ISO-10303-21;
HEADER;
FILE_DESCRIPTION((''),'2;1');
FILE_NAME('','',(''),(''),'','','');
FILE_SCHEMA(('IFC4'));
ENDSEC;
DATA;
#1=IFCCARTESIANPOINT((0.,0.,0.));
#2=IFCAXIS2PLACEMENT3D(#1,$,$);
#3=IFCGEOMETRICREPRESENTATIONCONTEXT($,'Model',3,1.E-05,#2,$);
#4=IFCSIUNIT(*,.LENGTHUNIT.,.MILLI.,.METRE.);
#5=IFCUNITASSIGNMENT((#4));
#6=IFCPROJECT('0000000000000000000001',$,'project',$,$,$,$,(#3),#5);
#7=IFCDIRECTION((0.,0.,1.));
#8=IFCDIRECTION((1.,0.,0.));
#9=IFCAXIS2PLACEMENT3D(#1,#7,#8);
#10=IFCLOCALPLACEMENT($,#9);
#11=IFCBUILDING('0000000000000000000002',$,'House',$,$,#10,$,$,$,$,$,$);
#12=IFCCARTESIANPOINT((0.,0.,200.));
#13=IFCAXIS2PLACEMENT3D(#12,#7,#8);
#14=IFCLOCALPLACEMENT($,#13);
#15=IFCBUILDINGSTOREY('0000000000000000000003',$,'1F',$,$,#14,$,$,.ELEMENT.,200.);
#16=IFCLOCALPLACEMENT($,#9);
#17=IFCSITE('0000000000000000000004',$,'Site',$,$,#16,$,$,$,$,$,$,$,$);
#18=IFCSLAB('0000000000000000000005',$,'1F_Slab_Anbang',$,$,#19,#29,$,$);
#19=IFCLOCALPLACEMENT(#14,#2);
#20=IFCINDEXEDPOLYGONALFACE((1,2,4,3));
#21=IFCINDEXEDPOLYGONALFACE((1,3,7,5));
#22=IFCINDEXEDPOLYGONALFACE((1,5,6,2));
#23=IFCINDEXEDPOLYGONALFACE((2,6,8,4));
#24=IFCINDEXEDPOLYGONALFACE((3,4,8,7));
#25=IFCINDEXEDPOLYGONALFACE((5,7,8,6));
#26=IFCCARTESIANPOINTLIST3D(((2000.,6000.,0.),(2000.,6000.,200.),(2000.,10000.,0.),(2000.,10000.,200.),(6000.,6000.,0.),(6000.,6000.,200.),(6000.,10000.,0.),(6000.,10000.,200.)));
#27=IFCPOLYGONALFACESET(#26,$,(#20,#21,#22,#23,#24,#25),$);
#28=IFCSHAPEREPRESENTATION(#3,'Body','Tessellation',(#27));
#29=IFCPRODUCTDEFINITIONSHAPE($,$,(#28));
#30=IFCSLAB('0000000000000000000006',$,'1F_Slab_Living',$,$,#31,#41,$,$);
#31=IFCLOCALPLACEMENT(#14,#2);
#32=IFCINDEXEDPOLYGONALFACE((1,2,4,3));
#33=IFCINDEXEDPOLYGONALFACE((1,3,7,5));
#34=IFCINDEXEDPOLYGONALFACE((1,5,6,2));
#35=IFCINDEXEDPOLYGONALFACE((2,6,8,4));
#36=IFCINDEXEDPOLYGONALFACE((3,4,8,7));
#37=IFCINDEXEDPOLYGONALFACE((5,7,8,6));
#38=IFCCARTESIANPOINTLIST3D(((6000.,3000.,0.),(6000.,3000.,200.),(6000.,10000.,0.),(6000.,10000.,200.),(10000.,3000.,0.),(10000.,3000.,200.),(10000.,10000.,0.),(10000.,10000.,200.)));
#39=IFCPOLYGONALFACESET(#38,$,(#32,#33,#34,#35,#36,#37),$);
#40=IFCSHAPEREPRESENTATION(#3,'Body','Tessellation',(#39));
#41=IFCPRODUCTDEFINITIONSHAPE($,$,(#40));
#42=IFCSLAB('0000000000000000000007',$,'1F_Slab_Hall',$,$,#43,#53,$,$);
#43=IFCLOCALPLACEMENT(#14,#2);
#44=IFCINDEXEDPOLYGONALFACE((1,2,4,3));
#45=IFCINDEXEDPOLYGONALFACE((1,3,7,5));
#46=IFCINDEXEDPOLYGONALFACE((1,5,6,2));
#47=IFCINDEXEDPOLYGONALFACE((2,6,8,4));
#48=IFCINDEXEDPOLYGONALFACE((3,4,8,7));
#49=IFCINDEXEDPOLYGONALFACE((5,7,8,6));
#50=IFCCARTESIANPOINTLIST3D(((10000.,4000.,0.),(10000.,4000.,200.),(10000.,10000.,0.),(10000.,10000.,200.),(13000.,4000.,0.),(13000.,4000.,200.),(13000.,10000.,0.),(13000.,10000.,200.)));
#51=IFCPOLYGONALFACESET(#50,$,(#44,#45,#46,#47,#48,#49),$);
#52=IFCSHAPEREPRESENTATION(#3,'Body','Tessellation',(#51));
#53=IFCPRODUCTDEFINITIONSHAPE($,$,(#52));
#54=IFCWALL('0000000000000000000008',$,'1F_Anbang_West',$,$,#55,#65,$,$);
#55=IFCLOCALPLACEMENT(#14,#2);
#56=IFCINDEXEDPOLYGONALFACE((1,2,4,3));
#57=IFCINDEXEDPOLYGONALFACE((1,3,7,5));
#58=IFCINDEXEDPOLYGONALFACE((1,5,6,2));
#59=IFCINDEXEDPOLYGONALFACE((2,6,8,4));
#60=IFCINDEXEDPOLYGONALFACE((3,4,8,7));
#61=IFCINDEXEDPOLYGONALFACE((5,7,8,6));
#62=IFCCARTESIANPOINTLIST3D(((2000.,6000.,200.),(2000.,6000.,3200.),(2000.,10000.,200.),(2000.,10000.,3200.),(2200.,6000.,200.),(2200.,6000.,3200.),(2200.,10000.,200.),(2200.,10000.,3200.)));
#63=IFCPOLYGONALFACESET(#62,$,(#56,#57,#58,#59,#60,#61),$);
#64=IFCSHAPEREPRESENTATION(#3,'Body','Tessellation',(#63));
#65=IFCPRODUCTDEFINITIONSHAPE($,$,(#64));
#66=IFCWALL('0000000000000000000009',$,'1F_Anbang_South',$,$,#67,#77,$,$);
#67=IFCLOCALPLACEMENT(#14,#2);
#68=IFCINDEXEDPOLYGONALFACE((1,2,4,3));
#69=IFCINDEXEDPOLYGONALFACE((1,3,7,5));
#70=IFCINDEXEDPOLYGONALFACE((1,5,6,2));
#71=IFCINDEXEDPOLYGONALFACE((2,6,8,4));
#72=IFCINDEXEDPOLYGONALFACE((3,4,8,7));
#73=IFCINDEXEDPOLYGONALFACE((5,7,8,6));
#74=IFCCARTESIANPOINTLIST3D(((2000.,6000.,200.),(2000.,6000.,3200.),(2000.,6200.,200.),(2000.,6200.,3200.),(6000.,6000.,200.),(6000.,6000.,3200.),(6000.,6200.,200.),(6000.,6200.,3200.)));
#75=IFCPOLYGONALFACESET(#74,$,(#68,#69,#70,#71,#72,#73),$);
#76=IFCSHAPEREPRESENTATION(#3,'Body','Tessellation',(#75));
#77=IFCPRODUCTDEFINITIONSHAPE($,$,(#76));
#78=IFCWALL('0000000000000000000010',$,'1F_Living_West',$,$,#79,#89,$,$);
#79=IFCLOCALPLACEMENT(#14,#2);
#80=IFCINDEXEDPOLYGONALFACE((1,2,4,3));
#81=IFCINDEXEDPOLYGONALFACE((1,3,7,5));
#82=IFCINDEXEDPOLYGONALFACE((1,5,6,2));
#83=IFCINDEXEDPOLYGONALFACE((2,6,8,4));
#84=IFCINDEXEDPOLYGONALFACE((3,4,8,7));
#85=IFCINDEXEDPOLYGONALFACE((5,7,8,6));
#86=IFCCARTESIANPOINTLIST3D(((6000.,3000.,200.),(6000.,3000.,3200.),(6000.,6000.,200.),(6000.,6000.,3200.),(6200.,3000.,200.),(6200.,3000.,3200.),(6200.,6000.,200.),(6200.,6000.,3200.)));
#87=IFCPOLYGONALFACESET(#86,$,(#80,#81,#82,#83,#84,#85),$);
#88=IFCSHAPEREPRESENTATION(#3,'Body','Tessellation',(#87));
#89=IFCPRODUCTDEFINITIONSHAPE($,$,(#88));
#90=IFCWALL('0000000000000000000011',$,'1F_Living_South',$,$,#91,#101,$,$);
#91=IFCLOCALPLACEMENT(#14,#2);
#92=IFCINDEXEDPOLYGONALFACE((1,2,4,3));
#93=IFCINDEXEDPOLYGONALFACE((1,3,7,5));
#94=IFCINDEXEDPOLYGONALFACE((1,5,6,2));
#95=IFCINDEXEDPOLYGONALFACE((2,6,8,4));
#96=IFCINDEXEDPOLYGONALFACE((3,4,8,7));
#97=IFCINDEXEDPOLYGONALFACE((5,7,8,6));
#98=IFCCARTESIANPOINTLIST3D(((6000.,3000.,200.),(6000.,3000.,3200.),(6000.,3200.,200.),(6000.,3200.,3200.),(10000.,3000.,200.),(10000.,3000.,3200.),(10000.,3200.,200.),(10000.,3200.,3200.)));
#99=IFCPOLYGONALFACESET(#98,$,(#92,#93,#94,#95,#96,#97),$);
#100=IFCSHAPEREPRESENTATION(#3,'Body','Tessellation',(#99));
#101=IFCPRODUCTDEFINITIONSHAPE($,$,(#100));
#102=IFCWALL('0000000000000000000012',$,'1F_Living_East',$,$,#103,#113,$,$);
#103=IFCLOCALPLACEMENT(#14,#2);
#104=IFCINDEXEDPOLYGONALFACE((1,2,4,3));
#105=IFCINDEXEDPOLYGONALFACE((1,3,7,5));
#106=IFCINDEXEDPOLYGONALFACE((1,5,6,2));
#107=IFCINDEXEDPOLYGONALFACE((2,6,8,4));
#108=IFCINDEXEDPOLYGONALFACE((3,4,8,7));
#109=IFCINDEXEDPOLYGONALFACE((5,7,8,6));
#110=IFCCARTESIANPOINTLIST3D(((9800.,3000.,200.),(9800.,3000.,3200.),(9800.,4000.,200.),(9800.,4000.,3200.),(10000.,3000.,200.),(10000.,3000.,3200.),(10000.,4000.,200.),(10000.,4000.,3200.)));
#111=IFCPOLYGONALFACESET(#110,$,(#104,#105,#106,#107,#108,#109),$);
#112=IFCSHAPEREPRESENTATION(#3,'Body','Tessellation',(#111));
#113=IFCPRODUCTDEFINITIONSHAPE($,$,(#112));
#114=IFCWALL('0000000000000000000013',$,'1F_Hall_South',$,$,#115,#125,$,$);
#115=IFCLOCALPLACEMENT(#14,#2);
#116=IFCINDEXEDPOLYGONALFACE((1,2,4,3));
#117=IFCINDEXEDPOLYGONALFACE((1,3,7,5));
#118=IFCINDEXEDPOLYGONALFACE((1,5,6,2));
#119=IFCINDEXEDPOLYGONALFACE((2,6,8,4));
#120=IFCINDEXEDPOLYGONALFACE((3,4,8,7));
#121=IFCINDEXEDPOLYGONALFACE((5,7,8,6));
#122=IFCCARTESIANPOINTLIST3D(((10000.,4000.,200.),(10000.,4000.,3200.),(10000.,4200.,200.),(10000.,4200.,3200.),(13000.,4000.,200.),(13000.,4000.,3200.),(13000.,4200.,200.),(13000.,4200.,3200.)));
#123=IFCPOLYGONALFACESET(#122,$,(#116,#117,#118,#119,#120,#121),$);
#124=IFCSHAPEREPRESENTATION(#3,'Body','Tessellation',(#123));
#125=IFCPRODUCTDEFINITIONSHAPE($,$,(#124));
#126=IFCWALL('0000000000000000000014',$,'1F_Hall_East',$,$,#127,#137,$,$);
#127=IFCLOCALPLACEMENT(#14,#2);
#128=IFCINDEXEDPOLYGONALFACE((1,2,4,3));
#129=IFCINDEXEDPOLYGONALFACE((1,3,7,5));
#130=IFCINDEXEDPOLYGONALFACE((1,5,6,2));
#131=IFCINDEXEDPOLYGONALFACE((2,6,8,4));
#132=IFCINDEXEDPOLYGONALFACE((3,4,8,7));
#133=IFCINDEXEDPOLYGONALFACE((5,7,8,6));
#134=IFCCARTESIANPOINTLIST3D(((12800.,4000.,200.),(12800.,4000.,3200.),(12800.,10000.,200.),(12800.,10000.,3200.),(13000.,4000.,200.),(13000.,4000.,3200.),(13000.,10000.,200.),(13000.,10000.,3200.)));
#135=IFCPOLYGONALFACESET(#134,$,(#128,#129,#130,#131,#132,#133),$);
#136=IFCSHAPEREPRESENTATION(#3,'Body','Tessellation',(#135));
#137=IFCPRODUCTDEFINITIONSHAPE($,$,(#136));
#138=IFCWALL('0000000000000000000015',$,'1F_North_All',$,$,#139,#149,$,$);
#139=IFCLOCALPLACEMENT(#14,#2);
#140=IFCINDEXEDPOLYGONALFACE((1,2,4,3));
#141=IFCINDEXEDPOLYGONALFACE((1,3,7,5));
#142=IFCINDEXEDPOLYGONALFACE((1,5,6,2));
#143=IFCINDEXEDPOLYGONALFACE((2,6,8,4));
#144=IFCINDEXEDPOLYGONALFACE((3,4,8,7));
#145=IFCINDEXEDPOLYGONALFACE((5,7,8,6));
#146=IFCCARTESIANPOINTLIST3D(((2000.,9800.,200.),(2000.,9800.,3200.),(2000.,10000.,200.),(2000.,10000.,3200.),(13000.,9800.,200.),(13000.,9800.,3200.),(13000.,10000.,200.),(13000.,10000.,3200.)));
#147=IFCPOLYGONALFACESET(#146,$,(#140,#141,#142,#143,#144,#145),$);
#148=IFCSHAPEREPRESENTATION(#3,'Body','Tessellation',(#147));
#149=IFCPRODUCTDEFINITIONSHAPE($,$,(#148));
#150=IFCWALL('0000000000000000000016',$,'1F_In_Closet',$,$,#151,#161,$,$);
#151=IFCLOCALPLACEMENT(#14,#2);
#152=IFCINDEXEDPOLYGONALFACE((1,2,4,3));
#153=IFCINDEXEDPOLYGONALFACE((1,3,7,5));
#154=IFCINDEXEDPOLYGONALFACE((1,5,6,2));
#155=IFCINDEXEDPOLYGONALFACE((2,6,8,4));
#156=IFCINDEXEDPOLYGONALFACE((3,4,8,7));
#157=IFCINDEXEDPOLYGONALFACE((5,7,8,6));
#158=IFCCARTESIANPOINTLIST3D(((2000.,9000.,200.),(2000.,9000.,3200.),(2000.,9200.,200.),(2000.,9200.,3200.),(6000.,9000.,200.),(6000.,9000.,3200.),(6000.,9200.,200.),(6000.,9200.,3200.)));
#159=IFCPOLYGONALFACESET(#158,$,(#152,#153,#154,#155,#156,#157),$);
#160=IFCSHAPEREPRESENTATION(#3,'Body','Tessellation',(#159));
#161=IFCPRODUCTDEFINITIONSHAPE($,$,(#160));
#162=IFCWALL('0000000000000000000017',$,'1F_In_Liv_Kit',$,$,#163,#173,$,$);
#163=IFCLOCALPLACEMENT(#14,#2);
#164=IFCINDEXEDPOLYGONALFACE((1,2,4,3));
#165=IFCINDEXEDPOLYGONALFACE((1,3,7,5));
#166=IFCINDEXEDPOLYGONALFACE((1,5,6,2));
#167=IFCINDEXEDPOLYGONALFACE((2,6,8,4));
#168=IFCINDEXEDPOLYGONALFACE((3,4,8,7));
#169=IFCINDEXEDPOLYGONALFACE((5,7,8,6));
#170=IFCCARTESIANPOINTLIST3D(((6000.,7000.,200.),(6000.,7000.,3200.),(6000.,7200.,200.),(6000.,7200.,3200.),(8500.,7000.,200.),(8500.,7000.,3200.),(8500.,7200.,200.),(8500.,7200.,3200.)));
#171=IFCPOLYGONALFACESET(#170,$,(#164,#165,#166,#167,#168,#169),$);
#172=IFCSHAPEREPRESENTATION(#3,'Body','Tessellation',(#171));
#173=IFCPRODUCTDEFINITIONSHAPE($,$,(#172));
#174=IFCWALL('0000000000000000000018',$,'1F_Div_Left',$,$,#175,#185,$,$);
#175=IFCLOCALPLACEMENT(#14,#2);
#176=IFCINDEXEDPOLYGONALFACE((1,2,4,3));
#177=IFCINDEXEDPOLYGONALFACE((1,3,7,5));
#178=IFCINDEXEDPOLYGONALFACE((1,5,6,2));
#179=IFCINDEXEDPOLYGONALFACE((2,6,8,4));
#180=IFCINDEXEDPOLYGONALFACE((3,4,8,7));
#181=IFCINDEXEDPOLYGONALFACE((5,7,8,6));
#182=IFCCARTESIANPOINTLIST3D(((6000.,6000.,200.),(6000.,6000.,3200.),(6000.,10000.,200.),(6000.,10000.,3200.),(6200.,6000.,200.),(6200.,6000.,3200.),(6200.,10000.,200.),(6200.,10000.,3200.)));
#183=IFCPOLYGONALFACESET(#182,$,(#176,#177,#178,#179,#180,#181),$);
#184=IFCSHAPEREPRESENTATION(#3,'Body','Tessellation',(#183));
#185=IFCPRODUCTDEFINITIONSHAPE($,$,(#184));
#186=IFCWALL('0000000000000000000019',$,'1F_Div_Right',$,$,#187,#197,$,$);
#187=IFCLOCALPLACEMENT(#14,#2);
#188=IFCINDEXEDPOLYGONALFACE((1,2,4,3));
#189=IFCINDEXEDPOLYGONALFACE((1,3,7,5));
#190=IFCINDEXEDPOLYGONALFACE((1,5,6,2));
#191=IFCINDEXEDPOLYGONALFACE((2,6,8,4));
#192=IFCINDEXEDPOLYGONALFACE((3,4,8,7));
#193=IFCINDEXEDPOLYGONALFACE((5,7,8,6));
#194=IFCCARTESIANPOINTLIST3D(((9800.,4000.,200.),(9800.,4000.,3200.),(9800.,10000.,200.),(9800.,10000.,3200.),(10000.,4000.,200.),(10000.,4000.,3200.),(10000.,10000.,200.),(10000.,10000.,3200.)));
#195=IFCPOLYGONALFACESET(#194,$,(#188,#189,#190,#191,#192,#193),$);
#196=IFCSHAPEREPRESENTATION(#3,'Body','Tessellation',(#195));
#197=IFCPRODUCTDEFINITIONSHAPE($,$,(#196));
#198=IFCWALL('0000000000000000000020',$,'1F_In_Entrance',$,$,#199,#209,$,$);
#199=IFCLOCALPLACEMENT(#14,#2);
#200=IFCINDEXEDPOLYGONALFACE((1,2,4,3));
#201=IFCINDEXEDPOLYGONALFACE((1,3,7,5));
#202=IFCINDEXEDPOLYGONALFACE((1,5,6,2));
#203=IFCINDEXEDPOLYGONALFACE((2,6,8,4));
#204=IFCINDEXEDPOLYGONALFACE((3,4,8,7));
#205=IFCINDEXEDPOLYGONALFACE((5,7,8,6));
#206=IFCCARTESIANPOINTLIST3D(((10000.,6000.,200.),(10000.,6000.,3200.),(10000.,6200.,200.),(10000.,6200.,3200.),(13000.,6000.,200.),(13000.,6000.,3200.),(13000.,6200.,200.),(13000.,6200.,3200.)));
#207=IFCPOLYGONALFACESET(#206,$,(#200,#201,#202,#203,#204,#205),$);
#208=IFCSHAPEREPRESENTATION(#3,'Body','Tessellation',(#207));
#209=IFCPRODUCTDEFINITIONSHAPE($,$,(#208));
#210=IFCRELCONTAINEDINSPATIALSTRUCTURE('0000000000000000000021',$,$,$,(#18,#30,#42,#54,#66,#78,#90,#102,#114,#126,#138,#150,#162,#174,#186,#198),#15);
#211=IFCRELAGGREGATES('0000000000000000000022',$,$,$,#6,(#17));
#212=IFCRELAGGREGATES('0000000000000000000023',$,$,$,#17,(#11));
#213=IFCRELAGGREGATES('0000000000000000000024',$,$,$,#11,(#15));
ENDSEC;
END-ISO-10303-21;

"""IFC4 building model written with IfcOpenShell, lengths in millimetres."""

from ifc_helpers import new_model, si_unit, frame, origin, origin_with_axes, place, context, project, spatial, rectangle, extrude, element, save


model = new_model("IFC4")

# Units and contexts
model_context = context("Model", 3, precision=1e-05, world=origin())
ifc_project = project(units=[si_unit("LENGTHUNIT", "METRE", prefix="MILLI")], contexts=[model_context])

# Site, building, storey
site_placement = place(None, origin_with_axes())
site = spatial("IfcSite", under=ifc_project, at=site_placement, Name="Site")
building_placement = place(None, origin_with_axes())
building = spatial("IfcBuilding", under=site, at=building_placement, Name="House")
storey_placement = place(None, frame((0.0, 0.0, 200.0), z_axis=(0.0, 0.0, 1.0), x_axis=(1.0, 0.0, 0.0)))
storey = spatial("IfcBuildingStorey", under=building, at=storey_placement, Name="1F", CompositionType="ELEMENT", Elevation=200.0)

# Slabs
slab_1_placement = place(None, frame((2000.0, 6000.0, 200.0), z_axis=(0.0, 0.0, 1.0), x_axis=(1.0, 0.0, 0.0)))
element("IfcSlab", 1, at=slab_1_placement, inside=storey, Name="1F_Slab_Anbang", context=model_context, shape_type="SweptSolid", body=[
    extrude(rectangle(XDim=4000.0, YDim=4000.0), frame((2000.0, 2000.0, 0.0)), (0.0, 0.0, 1.0), 200.0),
])
slab_2_placement = place(None, frame((6000.0, 3000.0, 200.0), z_axis=(0.0, 0.0, 1.0), x_axis=(1.0, 0.0, 0.0)))
element("IfcSlab", 2, at=slab_2_placement, inside=storey, Name="1F_Slab_Living", context=model_context, shape_type="SweptSolid", body=[
    extrude(rectangle(XDim=4000.0, YDim=7000.0), frame((2000.0, 3500.0, 0.0)), (0.0, 0.0, 1.0), 200.0),
])
slab_3_placement = place(None, frame((10000.0, 4000.0, 200.0), z_axis=(0.0, 0.0, 1.0), x_axis=(1.0, 0.0, 0.0)))
element("IfcSlab", 3, at=slab_3_placement, inside=storey, Name="1F_Slab_Hall", context=model_context, shape_type="SweptSolid", body=[
    extrude(rectangle(XDim=3000.0, YDim=6000.0), frame((1500.0, 3000.0, 0.0)), (0.0, 0.0, 1.0), 200.0),
])

# Walls
wall_1_placement = place(None, frame((2000.0, 6000.0, 400.0), z_axis=(0.0, 0.0, 1.0), x_axis=(1.0, 0.0, 0.0)))
element("IfcWall", 4, at=wall_1_placement, inside=storey, Name="1F_Anbang_West", context=model_context, shape_type="SweptSolid", body=[
    extrude(rectangle(XDim=200.0, YDim=4000.0), frame((100.0, 2000.0, 0.0)), (0.0, 0.0, 1.0), 3000.0),
])
wall_2_placement = place(None, frame((2000.0, 6000.0, 400.0), z_axis=(0.0, 0.0, 1.0), x_axis=(1.0, 0.0, 0.0)))
element("IfcWall", 5, at=wall_2_placement, inside=storey, Name="1F_Anbang_South", context=model_context, shape_type="SweptSolid", body=[
    extrude(rectangle(XDim=4000.0, YDim=200.0), frame((2000.0, 100.0, 0.0)), (0.0, 0.0, 1.0), 3000.0),
])
wall_3_placement = place(None, frame((6000.0, 3000.0, 400.0), z_axis=(0.0, 0.0, 1.0), x_axis=(1.0, 0.0, 0.0)))
element("IfcWall", 6, at=wall_3_placement, inside=storey, Name="1F_Living_West", context=model_context, shape_type="SweptSolid", body=[
    extrude(rectangle(XDim=200.0, YDim=3000.0), frame((100.0, 1500.0, 0.0)), (0.0, 0.0, 1.0), 3000.0),
])
wall_4_placement = place(None, frame((6000.0, 3000.0, 400.0), z_axis=(0.0, 0.0, 1.0), x_axis=(1.0, 0.0, 0.0)))
element("IfcWall", 7, at=wall_4_placement, inside=storey, Name="1F_Living_South", context=model_context, shape_type="SweptSolid", body=[
    extrude(rectangle(XDim=4000.0, YDim=200.0), frame((2000.0, 100.0, 0.0)), (0.0, 0.0, 1.0), 3000.0),
])
wall_5_placement = place(None, frame((9800.0, 3000.0, 400.0), z_axis=(0.0, 0.0, 1.0), x_axis=(1.0, 0.0, 0.0)))
element("IfcWall", 8, at=wall_5_placement, inside=storey, Name="1F_Living_East", context=model_context, shape_type="SweptSolid", body=[
    extrude(rectangle(XDim=200.0, YDim=1000.0), frame((100.0, 500.0, 0.0)), (0.0, 0.0, 1.0), 3000.0),
])
wall_6_placement = place(None, frame((10000.0, 4000.0, 400.0), z_axis=(0.0, 0.0, 1.0), x_axis=(1.0, 0.0, 0.0)))
element("IfcWall", 9, at=wall_6_placement, inside=storey, Name="1F_Hall_South", context=model_context, shape_type="SweptSolid", body=[
    extrude(rectangle(XDim=3000.0, YDim=200.0), frame((1500.0, 100.0, 0.0)), (0.0, 0.0, 1.0), 3000.0),
])
wall_7_placement = place(None, frame((12800.0, 4000.0, 400.0), z_axis=(0.0, 0.0, 1.0), x_axis=(1.0, 0.0, 0.0)))
element("IfcWall", 10, at=wall_7_placement, inside=storey, Name="1F_Hall_East", context=model_context, shape_type="SweptSolid", body=[
    extrude(rectangle(XDim=200.0, YDim=6000.0), frame((100.0, 3000.0, 0.0)), (0.0, 0.0, 1.0), 3000.0),
])
wall_8_placement = place(None, frame((2000.0, 9800.0, 400.0), z_axis=(0.0, 0.0, 1.0), x_axis=(1.0, 0.0, 0.0)))
element("IfcWall", 11, at=wall_8_placement, inside=storey, Name="1F_North_All", context=model_context, shape_type="SweptSolid", body=[
    extrude(rectangle(XDim=11000.0, YDim=200.0), frame((5500.0, 100.0, 0.0)), (0.0, 0.0, 1.0), 3000.0),
])
wall_9_placement = place(None, frame((2000.0, 9000.0, 400.0), z_axis=(0.0, 0.0, 1.0), x_axis=(1.0, 0.0, 0.0)))
element("IfcWall", 12, at=wall_9_placement, inside=storey, Name="1F_In_Closet", context=model_context, shape_type="SweptSolid", body=[
    extrude(rectangle(XDim=4000.0, YDim=200.0), frame((2000.0, 100.0, 0.0)), (0.0, 0.0, 1.0), 3000.0),
])
wall_10_placement = place(None, frame((6000.0, 7000.0, 400.0), z_axis=(0.0, 0.0, 1.0), x_axis=(1.0, 0.0, 0.0)))
element("IfcWall", 13, at=wall_10_placement, inside=storey, Name="1F_In_Liv_Kit", context=model_context, shape_type="SweptSolid", body=[
    extrude(rectangle(XDim=2500.0, YDim=200.0), frame((1250.0, 100.0, 0.0)), (0.0, 0.0, 1.0), 3000.0),
])
wall_11_placement = place(None, frame((6000.0, 6000.0, 400.0), z_axis=(0.0, 0.0, 1.0), x_axis=(1.0, 0.0, 0.0)))
element("IfcWall", 14, at=wall_11_placement, inside=storey, Name="1F_Div_Left", context=model_context, shape_type="SweptSolid", body=[
    extrude(rectangle(XDim=200.0, YDim=4000.0), frame((100.0, 2000.0, 0.0)), (0.0, 0.0, 1.0), 3000.0),
])
wall_12_placement = place(None, frame((9800.0, 4000.0, 400.0), z_axis=(0.0, 0.0, 1.0), x_axis=(1.0, 0.0, 0.0)))
element("IfcWall", 15, at=wall_12_placement, inside=storey, Name="1F_Div_Right", context=model_context, shape_type="SweptSolid", body=[
    extrude(rectangle(XDim=200.0, YDim=6000.0), frame((100.0, 3000.0, 0.0)), (0.0, 0.0, 1.0), 3000.0),
])
wall_13_placement = place(None, frame((10000.0, 6000.0, 400.0), z_axis=(0.0, 0.0, 1.0), x_axis=(1.0, 0.0, 0.0)))
element("IfcWall", 16, at=wall_13_placement, inside=storey, Name="1F_In_Entrance", context=model_context, shape_type="SweptSolid", body=[
    extrude(rectangle(XDim=3000.0, YDim=200.0), frame((1500.0, 100.0, 0.0)), (0.0, 0.0, 1.0), 3000.0),
])

save(model, "model.ifc")
